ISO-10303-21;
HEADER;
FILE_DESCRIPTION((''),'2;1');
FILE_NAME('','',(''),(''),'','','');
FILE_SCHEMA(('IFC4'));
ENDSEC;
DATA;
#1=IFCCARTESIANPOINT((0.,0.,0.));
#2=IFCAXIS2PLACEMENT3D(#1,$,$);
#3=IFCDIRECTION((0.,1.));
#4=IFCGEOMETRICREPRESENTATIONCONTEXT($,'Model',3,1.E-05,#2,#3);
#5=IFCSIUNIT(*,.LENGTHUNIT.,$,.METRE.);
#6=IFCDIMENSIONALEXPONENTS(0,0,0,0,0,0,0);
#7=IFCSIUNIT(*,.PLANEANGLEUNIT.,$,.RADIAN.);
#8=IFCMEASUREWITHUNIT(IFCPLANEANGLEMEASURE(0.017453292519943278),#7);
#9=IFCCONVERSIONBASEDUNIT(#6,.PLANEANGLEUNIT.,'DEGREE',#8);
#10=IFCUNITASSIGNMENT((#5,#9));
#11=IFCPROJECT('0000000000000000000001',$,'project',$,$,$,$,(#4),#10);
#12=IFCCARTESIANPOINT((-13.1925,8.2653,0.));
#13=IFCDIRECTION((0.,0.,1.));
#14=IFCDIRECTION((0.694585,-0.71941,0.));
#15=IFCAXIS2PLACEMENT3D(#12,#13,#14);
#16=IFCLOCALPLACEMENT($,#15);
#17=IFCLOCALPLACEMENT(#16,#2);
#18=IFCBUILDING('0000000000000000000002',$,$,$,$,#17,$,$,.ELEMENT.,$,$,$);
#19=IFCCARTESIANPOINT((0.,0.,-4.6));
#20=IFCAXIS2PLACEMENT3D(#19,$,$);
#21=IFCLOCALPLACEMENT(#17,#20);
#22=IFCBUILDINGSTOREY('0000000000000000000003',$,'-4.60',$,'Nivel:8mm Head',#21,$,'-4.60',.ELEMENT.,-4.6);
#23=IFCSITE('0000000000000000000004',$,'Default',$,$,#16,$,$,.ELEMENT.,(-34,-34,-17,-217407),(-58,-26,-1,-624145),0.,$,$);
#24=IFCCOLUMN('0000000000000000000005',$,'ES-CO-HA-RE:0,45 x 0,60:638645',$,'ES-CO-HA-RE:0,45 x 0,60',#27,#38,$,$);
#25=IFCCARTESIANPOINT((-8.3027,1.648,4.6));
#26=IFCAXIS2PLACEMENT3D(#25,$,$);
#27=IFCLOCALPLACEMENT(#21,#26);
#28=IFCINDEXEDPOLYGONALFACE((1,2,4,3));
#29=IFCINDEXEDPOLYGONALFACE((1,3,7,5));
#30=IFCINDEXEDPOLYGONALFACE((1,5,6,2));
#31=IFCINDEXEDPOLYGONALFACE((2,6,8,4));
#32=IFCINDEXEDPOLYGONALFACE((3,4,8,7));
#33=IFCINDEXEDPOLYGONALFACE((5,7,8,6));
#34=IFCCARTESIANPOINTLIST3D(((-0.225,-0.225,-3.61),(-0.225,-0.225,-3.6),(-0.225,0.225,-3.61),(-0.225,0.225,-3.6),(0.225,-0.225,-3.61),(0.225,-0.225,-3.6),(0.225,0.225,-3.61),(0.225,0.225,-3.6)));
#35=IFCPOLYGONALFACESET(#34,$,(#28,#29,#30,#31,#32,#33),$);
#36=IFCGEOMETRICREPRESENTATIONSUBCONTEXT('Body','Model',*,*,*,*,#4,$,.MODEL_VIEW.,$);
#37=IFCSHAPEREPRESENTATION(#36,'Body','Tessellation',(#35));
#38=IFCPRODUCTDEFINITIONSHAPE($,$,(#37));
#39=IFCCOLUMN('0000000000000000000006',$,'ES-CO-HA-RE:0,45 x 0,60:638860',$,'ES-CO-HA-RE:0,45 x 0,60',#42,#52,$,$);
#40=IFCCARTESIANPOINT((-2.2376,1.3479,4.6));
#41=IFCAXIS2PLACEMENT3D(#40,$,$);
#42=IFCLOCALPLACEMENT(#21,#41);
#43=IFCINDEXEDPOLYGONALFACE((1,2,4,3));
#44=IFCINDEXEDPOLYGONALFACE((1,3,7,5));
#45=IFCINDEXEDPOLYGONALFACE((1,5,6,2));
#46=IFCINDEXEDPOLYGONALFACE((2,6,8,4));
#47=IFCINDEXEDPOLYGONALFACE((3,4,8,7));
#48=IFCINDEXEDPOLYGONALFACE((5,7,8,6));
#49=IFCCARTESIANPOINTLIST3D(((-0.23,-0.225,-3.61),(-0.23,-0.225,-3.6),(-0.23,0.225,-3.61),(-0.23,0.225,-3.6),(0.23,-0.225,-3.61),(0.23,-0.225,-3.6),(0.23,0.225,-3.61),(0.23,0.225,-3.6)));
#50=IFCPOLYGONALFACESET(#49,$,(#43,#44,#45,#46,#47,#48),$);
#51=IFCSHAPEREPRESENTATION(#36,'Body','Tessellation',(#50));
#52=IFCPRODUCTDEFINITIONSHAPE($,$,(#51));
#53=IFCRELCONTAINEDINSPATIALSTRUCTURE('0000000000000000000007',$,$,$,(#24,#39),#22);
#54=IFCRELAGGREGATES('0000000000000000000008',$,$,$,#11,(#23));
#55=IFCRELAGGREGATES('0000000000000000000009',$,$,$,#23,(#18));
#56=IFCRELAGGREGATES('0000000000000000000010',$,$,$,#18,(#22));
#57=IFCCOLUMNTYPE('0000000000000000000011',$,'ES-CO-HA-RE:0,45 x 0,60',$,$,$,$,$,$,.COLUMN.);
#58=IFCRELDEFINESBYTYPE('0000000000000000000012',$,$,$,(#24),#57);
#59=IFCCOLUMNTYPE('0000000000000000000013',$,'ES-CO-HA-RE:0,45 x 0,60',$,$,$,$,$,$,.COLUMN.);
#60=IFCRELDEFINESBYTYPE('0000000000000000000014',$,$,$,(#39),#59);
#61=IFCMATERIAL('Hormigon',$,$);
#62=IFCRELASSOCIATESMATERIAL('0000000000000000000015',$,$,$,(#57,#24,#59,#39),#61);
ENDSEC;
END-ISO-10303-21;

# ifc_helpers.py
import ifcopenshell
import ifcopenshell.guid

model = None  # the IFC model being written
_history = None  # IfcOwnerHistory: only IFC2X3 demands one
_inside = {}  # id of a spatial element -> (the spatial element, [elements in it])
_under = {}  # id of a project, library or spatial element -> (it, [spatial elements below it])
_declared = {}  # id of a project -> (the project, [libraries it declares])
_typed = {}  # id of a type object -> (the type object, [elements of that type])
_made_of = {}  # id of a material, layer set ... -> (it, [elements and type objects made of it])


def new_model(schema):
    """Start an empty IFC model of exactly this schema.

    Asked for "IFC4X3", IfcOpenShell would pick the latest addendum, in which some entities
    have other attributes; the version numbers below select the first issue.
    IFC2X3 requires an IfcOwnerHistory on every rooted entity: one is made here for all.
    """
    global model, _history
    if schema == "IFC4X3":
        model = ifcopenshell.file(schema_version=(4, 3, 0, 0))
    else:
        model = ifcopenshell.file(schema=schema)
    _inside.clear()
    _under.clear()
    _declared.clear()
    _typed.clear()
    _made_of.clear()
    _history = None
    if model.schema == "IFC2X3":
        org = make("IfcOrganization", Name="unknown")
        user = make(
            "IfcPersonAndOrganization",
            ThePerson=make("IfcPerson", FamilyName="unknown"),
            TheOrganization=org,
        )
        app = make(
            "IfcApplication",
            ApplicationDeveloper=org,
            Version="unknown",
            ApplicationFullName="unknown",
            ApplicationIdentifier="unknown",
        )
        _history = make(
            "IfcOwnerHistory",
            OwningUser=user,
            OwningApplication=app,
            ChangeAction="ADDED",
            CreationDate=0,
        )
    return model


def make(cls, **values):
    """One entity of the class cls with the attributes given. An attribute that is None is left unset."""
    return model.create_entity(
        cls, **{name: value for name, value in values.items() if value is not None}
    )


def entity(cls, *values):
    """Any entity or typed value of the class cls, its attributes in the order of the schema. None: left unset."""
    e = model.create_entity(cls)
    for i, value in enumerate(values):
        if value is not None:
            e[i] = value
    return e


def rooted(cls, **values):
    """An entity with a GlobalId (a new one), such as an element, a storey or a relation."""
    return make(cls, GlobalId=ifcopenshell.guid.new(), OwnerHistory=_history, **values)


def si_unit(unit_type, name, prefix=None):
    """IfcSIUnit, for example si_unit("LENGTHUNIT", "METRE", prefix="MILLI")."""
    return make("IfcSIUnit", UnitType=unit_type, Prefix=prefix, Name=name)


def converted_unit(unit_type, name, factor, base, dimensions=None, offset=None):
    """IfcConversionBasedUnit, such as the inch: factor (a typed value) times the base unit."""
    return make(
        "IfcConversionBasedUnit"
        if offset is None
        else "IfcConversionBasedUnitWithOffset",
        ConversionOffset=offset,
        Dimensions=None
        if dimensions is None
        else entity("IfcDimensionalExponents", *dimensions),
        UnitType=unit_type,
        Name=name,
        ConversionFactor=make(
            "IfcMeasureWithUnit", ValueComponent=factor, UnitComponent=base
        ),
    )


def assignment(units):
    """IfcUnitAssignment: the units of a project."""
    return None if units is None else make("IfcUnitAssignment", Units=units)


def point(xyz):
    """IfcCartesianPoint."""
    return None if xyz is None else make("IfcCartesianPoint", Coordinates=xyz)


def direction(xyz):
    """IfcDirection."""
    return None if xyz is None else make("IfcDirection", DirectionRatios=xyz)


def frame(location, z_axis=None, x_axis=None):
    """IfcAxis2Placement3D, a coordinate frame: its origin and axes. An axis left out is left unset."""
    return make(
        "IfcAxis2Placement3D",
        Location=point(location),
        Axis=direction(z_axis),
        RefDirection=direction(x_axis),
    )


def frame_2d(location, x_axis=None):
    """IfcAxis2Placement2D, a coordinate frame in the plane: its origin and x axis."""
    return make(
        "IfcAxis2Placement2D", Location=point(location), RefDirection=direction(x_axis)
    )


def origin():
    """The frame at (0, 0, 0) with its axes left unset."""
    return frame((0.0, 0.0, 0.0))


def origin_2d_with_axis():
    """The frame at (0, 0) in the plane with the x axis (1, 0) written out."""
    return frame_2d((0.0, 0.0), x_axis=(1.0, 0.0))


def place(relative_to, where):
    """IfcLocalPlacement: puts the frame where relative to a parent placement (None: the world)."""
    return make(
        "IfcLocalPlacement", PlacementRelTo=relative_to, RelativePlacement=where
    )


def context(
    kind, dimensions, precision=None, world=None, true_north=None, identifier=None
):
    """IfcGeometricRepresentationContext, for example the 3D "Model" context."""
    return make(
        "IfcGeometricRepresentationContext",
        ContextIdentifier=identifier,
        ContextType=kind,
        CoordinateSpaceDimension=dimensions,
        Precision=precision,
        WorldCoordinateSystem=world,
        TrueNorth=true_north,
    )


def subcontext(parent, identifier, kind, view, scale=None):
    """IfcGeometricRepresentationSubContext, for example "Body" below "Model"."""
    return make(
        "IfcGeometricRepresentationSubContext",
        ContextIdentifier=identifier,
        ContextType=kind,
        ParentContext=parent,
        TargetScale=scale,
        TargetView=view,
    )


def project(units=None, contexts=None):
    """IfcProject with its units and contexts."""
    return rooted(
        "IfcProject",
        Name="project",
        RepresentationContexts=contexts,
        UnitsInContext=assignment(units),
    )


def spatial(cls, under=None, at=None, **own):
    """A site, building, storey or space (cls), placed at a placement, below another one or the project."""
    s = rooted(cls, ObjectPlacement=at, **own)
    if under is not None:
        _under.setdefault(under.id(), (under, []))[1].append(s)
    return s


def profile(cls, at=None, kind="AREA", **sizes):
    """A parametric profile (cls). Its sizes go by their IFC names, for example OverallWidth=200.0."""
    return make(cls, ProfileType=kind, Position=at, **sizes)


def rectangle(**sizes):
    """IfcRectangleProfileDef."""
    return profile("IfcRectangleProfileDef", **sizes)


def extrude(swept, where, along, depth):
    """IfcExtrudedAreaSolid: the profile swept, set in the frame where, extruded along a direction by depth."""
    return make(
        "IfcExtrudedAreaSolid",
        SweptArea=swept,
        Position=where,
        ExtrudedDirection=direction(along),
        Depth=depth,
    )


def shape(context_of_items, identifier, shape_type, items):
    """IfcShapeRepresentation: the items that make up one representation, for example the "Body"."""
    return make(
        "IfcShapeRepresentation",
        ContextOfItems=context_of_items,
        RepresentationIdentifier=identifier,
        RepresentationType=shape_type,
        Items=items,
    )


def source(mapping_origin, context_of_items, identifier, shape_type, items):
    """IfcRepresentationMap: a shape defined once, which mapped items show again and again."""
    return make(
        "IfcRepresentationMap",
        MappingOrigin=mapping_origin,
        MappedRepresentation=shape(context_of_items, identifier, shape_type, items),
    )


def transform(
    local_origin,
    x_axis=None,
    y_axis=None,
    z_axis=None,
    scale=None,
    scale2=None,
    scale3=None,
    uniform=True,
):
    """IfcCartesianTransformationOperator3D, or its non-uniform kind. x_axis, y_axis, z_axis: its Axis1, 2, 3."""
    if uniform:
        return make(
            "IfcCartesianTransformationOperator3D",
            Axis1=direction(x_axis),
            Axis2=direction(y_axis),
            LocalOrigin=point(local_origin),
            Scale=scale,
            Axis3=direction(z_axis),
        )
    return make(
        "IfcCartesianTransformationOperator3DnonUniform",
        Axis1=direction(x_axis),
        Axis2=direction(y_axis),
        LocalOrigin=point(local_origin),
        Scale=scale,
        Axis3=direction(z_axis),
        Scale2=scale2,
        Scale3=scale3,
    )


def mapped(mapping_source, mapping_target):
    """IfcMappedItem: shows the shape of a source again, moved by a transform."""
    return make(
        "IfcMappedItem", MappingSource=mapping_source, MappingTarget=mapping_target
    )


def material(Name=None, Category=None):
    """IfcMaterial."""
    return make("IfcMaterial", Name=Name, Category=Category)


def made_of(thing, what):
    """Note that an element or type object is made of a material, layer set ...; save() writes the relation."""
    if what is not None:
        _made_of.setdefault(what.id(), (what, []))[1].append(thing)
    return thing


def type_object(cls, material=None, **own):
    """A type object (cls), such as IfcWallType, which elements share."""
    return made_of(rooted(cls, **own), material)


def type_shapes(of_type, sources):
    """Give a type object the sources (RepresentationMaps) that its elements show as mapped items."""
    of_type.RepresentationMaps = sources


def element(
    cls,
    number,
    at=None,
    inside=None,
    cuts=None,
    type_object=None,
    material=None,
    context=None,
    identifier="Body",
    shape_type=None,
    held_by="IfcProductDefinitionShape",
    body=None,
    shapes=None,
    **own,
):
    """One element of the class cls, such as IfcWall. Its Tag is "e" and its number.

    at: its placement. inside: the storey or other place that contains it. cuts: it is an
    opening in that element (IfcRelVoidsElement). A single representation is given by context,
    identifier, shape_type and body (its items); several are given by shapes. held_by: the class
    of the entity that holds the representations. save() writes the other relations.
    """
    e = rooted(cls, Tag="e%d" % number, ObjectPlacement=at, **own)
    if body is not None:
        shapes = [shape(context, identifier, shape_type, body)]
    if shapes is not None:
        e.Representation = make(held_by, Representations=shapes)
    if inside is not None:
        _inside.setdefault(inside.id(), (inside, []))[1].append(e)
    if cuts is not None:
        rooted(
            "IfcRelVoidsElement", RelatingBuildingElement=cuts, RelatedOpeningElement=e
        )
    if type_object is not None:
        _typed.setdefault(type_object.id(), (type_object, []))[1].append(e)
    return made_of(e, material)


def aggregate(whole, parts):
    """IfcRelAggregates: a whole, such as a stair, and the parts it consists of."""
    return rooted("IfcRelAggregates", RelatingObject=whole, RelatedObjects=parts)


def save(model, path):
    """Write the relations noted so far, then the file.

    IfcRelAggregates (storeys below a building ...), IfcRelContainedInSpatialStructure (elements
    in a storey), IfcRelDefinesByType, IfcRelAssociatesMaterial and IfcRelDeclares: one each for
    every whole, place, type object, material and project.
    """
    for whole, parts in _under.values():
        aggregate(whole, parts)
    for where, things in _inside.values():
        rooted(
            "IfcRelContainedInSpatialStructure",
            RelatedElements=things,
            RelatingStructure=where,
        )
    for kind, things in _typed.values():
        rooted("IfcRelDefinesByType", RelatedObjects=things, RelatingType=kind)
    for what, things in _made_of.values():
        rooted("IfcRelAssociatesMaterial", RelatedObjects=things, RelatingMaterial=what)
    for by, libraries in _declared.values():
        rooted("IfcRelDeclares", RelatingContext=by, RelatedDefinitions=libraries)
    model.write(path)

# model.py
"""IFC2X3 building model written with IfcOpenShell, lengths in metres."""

from ifc_helpers import new_model, entity, si_unit, converted_unit, direction, frame, origin, origin_2d_with_axis, place, context, subcontext, project, spatial, rectangle, extrude, source, transform, mapped, material, type_object, type_shapes, element, save


model = new_model("IFC2X3")

# Units and contexts
model_context = context("Model", 3, precision=1e-05, world=origin(), true_north=direction((0.0, 1.0)))
body_context = subcontext(model_context, "Body", "Model", "MODEL_VIEW")
ifc_project = project(units=[si_unit("LENGTHUNIT", "METRE"), converted_unit("PLANEANGLEUNIT", "DEGREE", entity("IfcPlaneAngleMeasure", 0.017453292519943278), si_unit("PLANEANGLEUNIT", "RADIAN"), dimensions=[0, 0, 0, 0, 0, 0, 0])], contexts=[model_context])

# Site, building, storey
site_placement = place(None, frame((-13.1925, 8.2653, 0.0), z_axis=(0.0, 0.0, 1.0), x_axis=(0.694585, -0.71941, 0.0)))
site = spatial("IfcSite", under=ifc_project, at=site_placement, Name="Default", CompositionType="ELEMENT", RefLatitude=(-34, -34, -17, -217407), RefLongitude=(-58, -26, -1, -624145), RefElevation=0.0)
building_placement = place(site_placement, origin())
building = spatial("IfcBuilding", under=site, at=building_placement, CompositionType="ELEMENT")
storey_placement = place(building_placement, frame((0.0, 0.0, -4.6)))
storey = spatial("IfcBuildingStorey", under=building, at=storey_placement, Name="-4.60", ObjectType="Nivel:8mm Head", LongName="-4.60", CompositionType="ELEMENT", Elevation=-4.6)

# Columns
ifc_material_1 = material(Name="Hormigon")
column_type_1 = type_object("IfcColumnType", Name="ES-CO-HA-RE:0,45 x 0,60", PredefinedType="COLUMN", material=ifc_material_1)
shared_shape_1 = source(origin(), body_context, "Body", "SweptSolid", [
    extrude(rectangle(XDim=0.45, YDim=0.45, at=origin_2d_with_axis()), frame((0.0, 0.0, -3.61), z_axis=(0.0, 0.0, 1.0), x_axis=(-1.0, 0.0, 0.0)), (0.0, 0.0, 1.0), 0.01),
])
type_shapes(column_type_1, [shared_shape_1])
column_1_placement = place(storey_placement, frame((-8.3027, 1.648, 4.6)))
element("IfcColumn", 1, at=column_1_placement, inside=storey, type_object=column_type_1, material=ifc_material_1, Name="ES-CO-HA-RE:0,45 x 0,60:638645", ObjectType="ES-CO-HA-RE:0,45 x 0,60", context=body_context, shape_type="MappedRepresentation", body=[
    mapped(shared_shape_1, transform((0.0, 0.0, 0.0), scale=1.0)),
])
column_type_2 = type_object("IfcColumnType", Name="ES-CO-HA-RE:0,45 x 0,60", PredefinedType="COLUMN", material=ifc_material_1)
shared_shape_2 = source(origin(), body_context, "Body", "SweptSolid", [
    extrude(rectangle(XDim=0.46, YDim=0.45, at=origin_2d_with_axis()), frame((0.0, 0.0, -3.61), z_axis=(0.0, 0.0, 1.0), x_axis=(-1.0, 0.0, 0.0)), (0.0, 0.0, 1.0), 0.01),
])
type_shapes(column_type_2, [shared_shape_2])
column_2_placement = place(storey_placement, frame((-2.2376, 1.3479, 4.6)))
element("IfcColumn", 2, at=column_2_placement, inside=storey, type_object=column_type_2, material=ifc_material_1, Name="ES-CO-HA-RE:0,45 x 0,60:638860", ObjectType="ES-CO-HA-RE:0,45 x 0,60", context=body_context, shape_type="MappedRepresentation", body=[
    mapped(shared_shape_2, transform((0.0, 0.0, 0.0), scale=1.0)),
])

save(model, "model.ifc")
